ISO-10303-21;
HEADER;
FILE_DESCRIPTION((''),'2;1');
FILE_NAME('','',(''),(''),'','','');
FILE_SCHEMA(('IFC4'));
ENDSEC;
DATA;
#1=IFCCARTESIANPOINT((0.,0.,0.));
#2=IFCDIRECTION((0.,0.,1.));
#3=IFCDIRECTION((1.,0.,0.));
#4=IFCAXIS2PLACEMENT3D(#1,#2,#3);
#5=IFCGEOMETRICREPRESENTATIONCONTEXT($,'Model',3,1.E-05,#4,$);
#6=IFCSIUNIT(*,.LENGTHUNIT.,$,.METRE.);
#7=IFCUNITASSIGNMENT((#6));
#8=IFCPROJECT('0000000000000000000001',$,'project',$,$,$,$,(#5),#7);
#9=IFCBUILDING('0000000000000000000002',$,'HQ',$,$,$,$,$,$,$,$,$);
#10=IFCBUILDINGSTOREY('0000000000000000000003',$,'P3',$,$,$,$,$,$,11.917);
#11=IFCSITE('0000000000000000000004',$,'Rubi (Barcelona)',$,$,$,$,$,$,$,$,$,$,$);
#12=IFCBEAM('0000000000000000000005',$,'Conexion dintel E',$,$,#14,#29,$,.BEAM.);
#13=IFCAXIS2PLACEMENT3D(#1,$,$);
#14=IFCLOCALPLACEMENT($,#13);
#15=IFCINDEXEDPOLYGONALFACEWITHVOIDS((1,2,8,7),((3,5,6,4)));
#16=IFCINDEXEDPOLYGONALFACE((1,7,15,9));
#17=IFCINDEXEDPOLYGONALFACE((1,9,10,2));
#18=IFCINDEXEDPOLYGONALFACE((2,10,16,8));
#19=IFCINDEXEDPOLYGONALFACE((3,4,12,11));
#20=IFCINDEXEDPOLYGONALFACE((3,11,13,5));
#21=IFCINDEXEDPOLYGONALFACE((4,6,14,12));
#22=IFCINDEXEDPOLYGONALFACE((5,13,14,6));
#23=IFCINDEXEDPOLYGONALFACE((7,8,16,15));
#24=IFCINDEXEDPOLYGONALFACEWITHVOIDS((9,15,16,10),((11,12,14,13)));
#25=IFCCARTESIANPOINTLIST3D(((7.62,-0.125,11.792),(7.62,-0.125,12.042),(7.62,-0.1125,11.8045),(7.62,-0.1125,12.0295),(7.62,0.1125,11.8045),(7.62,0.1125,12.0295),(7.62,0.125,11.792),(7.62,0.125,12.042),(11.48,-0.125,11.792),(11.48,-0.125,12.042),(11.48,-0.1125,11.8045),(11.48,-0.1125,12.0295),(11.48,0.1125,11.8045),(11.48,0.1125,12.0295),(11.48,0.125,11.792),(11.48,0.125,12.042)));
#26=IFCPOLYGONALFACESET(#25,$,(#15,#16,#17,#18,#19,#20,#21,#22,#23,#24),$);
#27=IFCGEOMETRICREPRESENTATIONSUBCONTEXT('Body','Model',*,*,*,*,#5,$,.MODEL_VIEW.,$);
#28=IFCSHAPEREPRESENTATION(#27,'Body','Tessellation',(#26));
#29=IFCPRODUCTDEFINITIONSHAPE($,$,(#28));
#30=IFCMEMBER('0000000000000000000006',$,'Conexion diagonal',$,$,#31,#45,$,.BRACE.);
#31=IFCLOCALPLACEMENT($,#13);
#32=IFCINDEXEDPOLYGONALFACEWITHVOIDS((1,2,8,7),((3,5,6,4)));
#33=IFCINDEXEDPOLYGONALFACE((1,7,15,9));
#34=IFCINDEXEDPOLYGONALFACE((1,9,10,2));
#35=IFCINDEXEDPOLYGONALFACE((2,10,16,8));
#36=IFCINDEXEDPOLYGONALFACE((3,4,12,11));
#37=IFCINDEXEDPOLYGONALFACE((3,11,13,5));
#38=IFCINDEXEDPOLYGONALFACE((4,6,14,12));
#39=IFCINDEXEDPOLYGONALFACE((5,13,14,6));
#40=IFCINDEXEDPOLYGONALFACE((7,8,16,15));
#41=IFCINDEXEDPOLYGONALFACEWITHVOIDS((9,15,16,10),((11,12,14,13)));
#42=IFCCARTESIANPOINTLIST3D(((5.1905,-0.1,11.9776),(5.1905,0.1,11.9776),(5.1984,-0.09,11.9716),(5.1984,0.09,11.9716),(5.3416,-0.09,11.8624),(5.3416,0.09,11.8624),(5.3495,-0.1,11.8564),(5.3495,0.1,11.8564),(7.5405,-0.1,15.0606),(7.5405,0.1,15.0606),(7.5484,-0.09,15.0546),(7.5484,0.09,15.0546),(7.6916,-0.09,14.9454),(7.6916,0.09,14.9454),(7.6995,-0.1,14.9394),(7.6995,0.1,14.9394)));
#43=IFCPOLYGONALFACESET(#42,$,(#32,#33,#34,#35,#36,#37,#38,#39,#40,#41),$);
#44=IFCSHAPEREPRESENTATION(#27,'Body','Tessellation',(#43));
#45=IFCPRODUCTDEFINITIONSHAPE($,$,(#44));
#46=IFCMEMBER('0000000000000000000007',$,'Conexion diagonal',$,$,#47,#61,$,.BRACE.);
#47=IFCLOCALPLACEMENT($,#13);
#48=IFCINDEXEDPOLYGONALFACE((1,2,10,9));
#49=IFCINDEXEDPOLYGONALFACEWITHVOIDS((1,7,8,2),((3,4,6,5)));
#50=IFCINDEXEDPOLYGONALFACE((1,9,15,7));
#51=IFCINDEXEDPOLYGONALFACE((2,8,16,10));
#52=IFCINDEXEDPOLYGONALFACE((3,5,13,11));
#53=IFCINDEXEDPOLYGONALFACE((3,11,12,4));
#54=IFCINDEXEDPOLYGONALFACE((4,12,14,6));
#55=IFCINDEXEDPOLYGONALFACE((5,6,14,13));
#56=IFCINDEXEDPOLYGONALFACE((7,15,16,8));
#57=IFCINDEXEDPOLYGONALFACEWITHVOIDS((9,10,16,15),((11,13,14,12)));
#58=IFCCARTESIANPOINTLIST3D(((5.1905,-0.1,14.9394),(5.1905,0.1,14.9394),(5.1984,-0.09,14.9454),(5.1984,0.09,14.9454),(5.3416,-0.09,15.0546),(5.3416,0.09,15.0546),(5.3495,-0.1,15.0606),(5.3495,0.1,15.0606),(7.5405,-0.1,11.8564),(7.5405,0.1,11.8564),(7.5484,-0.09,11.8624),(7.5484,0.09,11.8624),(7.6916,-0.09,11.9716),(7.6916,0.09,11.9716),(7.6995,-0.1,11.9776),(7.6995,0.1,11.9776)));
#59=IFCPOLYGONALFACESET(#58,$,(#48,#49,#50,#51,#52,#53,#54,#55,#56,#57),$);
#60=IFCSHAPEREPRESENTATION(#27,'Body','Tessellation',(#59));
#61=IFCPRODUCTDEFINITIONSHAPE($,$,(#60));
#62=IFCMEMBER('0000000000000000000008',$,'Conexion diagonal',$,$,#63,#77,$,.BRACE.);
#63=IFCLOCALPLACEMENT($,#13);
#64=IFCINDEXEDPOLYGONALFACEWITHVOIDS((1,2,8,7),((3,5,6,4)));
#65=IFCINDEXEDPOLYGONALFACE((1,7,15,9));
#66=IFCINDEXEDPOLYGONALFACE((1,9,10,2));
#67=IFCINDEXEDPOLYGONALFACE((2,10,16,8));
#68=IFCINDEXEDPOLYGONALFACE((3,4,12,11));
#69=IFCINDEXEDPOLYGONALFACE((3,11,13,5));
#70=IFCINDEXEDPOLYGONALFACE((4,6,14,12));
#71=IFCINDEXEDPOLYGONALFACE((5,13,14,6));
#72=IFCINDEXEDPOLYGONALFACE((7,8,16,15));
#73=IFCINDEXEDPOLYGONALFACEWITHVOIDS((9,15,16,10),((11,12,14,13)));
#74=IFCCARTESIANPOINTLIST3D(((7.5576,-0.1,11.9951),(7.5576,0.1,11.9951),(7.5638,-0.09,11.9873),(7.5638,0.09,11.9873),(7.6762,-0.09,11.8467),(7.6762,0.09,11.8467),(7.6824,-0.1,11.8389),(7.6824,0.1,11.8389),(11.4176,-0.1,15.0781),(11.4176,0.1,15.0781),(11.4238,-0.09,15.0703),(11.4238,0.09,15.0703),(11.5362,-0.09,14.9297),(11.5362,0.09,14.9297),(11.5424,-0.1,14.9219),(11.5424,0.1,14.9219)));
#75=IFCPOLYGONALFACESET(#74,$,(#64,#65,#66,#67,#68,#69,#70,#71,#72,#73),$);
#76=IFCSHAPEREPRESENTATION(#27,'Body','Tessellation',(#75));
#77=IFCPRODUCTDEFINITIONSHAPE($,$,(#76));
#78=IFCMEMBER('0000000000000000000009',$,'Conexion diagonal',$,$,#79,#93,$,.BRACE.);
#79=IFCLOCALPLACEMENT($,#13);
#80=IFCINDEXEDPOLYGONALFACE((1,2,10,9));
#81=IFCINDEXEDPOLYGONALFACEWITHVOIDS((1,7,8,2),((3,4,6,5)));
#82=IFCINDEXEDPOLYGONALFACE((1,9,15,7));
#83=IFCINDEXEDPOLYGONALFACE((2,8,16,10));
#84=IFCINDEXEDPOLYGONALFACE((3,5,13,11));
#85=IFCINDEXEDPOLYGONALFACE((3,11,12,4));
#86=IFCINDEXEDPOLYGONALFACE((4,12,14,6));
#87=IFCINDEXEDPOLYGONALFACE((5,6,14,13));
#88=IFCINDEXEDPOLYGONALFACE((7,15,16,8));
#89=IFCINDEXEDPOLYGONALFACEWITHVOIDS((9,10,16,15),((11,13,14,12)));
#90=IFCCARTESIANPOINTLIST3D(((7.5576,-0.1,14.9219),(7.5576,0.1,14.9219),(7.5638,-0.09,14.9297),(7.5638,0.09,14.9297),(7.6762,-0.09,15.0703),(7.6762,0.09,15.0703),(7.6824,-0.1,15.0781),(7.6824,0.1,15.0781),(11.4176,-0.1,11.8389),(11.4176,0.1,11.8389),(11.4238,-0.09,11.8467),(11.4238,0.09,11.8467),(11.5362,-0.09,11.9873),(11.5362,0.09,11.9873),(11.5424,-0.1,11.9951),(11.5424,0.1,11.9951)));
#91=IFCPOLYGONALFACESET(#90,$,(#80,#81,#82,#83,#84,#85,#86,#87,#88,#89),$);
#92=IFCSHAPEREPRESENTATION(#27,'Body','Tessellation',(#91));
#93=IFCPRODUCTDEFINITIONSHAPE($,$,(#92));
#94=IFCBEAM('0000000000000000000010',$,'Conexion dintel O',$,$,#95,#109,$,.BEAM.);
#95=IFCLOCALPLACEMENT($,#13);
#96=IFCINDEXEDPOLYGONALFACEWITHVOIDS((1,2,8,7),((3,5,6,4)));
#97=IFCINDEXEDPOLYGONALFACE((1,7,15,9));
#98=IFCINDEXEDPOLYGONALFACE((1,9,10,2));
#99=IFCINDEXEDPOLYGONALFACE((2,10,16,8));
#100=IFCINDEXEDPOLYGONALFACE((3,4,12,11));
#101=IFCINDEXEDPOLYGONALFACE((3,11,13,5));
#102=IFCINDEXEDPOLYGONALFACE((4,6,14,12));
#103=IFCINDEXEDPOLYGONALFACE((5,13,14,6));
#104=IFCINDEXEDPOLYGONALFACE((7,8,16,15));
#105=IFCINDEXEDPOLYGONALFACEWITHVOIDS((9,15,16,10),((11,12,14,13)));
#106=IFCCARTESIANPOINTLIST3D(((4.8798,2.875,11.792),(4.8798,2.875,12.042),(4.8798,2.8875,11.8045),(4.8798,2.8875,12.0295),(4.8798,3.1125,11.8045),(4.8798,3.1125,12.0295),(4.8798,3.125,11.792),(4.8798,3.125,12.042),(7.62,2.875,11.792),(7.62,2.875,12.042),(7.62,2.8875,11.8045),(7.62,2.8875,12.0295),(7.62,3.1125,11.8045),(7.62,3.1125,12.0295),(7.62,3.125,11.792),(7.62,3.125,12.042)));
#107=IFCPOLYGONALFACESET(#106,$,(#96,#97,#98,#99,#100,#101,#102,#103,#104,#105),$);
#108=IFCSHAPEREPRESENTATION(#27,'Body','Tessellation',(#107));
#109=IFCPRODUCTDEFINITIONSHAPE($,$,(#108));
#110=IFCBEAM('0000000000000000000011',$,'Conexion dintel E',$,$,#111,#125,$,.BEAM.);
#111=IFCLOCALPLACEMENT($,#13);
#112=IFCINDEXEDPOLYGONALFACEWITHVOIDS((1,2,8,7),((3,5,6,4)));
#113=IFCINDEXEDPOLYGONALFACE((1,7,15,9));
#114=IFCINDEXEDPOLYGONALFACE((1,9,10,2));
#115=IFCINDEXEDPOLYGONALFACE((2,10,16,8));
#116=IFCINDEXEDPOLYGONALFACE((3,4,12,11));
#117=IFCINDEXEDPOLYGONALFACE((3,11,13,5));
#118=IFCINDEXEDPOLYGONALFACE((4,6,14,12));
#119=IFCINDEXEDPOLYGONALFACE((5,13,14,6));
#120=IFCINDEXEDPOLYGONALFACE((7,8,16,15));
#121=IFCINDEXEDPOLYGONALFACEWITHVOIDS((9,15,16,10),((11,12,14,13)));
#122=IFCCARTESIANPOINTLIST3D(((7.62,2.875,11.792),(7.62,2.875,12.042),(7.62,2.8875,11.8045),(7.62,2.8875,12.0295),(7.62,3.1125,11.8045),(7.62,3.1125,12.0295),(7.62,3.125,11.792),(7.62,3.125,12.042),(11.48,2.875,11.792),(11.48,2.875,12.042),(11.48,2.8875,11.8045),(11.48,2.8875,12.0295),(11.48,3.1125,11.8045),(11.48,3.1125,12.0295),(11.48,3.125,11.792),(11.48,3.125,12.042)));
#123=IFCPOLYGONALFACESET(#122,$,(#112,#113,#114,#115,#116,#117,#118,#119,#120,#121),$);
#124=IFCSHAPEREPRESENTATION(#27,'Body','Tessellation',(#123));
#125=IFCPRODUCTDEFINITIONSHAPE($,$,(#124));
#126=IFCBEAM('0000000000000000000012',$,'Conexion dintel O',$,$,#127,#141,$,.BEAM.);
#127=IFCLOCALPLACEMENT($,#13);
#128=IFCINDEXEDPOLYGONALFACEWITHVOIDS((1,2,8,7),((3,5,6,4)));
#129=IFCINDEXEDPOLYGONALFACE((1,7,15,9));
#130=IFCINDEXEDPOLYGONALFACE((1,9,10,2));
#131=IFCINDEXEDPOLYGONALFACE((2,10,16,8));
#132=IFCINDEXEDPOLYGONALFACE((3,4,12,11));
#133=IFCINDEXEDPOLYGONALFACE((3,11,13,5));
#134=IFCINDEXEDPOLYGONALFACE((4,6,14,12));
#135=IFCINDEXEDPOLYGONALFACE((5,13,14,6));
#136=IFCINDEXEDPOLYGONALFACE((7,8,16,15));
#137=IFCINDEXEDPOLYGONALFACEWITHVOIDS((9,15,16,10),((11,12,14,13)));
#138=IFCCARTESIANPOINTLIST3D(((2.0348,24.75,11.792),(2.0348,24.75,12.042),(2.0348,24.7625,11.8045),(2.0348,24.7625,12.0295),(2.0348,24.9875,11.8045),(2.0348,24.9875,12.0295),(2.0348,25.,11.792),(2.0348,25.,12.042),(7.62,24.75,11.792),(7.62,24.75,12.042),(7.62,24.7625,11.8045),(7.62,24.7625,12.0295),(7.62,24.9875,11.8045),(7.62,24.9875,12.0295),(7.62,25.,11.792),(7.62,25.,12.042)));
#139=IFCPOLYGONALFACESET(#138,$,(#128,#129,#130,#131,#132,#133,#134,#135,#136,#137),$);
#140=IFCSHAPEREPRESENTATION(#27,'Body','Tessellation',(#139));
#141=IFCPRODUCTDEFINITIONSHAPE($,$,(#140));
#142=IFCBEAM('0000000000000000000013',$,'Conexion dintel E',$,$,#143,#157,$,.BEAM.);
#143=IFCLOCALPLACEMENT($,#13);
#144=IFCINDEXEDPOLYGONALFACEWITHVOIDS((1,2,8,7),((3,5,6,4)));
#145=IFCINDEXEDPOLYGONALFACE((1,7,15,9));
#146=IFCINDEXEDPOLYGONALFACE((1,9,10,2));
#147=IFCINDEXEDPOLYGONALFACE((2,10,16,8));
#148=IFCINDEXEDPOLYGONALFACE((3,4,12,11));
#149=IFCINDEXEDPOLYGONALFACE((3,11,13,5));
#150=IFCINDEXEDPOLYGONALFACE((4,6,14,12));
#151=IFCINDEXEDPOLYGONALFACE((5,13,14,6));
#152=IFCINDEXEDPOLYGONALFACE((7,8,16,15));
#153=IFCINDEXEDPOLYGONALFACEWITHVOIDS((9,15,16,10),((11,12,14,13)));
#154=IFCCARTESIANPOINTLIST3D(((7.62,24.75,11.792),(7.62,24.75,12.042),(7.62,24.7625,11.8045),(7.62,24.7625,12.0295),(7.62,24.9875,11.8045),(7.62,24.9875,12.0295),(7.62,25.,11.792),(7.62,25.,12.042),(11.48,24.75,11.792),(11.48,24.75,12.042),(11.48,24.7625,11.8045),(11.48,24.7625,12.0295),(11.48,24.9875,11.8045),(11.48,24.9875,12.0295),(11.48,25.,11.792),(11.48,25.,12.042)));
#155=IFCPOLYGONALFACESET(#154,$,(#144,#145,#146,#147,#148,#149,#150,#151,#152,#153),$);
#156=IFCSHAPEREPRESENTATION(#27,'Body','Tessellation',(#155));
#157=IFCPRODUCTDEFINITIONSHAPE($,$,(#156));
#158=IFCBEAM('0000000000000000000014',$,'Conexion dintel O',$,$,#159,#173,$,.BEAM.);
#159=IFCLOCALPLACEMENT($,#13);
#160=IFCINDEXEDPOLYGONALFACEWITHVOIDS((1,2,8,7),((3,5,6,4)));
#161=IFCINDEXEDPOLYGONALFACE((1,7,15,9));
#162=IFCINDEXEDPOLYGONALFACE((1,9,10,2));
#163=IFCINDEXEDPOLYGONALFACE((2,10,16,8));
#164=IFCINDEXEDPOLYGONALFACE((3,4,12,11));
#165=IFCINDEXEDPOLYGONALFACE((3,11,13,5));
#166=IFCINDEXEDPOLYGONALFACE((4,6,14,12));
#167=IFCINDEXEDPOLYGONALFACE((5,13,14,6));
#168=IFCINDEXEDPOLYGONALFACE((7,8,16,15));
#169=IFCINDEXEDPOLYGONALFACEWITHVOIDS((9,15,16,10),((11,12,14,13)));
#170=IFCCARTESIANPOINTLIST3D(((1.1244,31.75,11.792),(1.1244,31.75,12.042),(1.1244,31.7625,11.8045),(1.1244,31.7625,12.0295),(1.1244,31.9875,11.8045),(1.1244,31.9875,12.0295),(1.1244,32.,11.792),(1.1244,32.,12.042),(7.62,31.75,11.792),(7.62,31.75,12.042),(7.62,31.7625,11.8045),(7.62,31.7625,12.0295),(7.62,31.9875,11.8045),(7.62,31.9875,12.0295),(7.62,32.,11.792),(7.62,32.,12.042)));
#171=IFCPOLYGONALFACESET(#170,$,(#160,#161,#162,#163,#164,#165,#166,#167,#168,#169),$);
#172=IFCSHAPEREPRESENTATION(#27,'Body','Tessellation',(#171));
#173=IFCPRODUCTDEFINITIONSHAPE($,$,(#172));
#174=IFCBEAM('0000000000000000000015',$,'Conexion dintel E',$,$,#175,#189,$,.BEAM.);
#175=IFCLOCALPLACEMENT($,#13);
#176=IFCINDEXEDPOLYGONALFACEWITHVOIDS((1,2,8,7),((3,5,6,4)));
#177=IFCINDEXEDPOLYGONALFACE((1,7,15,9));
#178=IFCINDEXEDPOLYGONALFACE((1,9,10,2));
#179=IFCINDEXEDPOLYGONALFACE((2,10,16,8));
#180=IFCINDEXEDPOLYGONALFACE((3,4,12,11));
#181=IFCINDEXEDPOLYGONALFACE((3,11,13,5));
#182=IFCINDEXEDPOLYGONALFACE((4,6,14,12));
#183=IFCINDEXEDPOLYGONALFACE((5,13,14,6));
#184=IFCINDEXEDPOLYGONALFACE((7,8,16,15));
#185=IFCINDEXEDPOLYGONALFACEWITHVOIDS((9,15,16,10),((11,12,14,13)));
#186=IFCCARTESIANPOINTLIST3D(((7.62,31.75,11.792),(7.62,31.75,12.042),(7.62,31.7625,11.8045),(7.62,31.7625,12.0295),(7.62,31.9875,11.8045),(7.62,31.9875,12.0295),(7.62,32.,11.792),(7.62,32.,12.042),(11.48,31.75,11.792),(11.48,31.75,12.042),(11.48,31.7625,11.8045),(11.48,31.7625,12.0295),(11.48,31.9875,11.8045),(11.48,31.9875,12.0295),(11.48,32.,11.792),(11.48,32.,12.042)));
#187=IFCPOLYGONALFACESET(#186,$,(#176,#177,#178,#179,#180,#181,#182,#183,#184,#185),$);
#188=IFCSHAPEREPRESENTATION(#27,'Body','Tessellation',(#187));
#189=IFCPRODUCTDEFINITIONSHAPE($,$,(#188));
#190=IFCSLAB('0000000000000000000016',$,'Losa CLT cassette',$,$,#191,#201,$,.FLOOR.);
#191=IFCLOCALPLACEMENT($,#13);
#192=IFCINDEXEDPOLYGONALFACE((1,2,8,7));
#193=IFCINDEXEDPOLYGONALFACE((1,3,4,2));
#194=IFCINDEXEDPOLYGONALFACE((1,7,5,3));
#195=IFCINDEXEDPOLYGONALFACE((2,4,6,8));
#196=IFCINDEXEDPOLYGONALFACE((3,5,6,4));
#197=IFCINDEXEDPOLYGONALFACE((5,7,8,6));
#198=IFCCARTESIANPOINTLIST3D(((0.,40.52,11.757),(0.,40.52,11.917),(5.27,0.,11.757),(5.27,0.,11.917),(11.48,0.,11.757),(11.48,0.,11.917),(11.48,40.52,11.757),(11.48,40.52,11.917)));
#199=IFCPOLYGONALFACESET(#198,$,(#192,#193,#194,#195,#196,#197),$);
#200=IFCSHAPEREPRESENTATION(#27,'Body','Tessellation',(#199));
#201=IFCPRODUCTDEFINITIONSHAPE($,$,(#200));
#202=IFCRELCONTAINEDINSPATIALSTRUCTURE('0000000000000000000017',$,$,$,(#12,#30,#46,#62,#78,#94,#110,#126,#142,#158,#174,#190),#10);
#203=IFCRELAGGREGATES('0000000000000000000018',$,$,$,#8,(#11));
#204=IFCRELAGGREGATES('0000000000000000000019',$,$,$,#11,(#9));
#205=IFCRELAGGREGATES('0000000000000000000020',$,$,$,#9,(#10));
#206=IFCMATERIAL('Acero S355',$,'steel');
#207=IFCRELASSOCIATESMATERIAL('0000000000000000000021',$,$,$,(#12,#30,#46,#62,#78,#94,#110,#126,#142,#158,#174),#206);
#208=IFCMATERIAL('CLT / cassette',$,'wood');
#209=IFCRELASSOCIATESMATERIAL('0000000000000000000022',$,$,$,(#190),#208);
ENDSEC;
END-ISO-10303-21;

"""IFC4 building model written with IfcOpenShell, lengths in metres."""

from ifc_helpers import new_model, si_unit, frame, origin_with_axes, place, context, subcontext, project, spatial, polyline, hollow_rectangle, outline, extrude, material, element, save


model = new_model("IFC4")

# Units and contexts
model_context = context("Model", 3, precision=1e-05, world=origin_with_axes())
body_context = subcontext(model_context, "Body", "Model", "MODEL_VIEW")
ifc_project = project(units=[si_unit("LENGTHUNIT", "METRE")], contexts=[model_context])

# Site, building, storey
site = spatial("IfcSite", under=ifc_project, Name="Rubi (Barcelona)")
building = spatial("IfcBuilding", under=site, Name="HQ")
storey = spatial("IfcBuildingStorey", under=building, Name="P3", Elevation=11.917)

# Beam
ifc_material_1 = material(Name="Acero S355", Category="steel")
beam_1_placement = place(None, origin_with_axes())
element("IfcBeam", 1, at=beam_1_placement, inside=storey, material=ifc_material_1, Name="Conexion dintel E", PredefinedType="BEAM", context=body_context, shape_type="SweptSolid", body=[
    extrude(hollow_rectangle(XDim=0.25, YDim=0.25, WallThickness=0.0125), frame((7.62, 0.0, 11.917), z_axis=(1.0, 0.0, 0.0), x_axis=(0.0, 1.0, 0.0)), (0.0, 0.0, 1.0), 3.86),
])

# Members
member_1_placement = place(None, origin_with_axes())
element("IfcMember", 2, at=member_1_placement, inside=storey, material=ifc_material_1, Name="Conexion diagonal", PredefinedType="BRACE", context=body_context, shape_type="SweptSolid", body=[
    extrude(hollow_rectangle(XDim=0.2, YDim=0.2, WallThickness=0.01), frame((5.27, 0.0, 11.917), z_axis=(0.606214, 0.0, 0.795301), x_axis=(0.0, 1.0, 0.0)), (0.0, 0.0, 1.0), 3.8765),
])
member_2_placement = place(None, origin_with_axes())
element("IfcMember", 3, at=member_2_placement, inside=storey, material=ifc_material_1, Name="Conexion diagonal", PredefinedType="BRACE", context=body_context, shape_type="SweptSolid", body=[
    extrude(hollow_rectangle(XDim=0.2, YDim=0.2, WallThickness=0.01), frame((7.62, 0.0, 11.917), z_axis=(-0.606214, 0.0, 0.795301), x_axis=(0.0, -1.0, 0.0)), (0.0, 0.0, 1.0), 3.8765),
])
member_3_placement = place(None, origin_with_axes())
element("IfcMember", 4, at=member_3_placement, inside=storey, material=ifc_material_1, Name="Conexion diagonal", PredefinedType="BRACE", context=body_context, shape_type="SweptSolid", body=[
    extrude(hollow_rectangle(XDim=0.2, YDim=0.2, WallThickness=0.01), frame((7.62, 0.0, 11.917), z_axis=(0.781362, 0.0, 0.624078), x_axis=(0.0, 1.0, 0.0)), (0.0, 0.0, 1.0), 4.9401),
])
member_4_placement = place(None, origin_with_axes())
element("IfcMember", 5, at=member_4_placement, inside=storey, material=ifc_material_1, Name="Conexion diagonal", PredefinedType="BRACE", context=body_context, shape_type="SweptSolid", body=[
    extrude(hollow_rectangle(XDim=0.2, YDim=0.2, WallThickness=0.01), frame((11.48, 0.0, 11.917), z_axis=(-0.781362, 0.0, 0.624078), x_axis=(0.0, -1.0, 0.0)), (0.0, 0.0, 1.0), 4.9401),
])

# Beams
beam_2_placement = place(None, origin_with_axes())
element("IfcBeam", 6, at=beam_2_placement, inside=storey, material=ifc_material_1, Name="Conexion dintel O", PredefinedType="BEAM", context=body_context, shape_type="SweptSolid", body=[
    extrude(hollow_rectangle(XDim=0.25, YDim=0.25, WallThickness=0.0125), frame((4.8798, 3.0, 11.917), z_axis=(1.0, 0.0, 0.0), x_axis=(0.0, 1.0, 0.0)), (0.0, 0.0, 1.0), 2.7402),
])
beam_3_placement = place(None, origin_with_axes())
element("IfcBeam", 7, at=beam_3_placement, inside=storey, material=ifc_material_1, Name="Conexion dintel E", PredefinedType="BEAM", context=body_context, shape_type="SweptSolid", body=[
    extrude(hollow_rectangle(XDim=0.25, YDim=0.25, WallThickness=0.0125), frame((7.62, 3.0, 11.917), z_axis=(1.0, 0.0, 0.0), x_axis=(0.0, 1.0, 0.0)), (0.0, 0.0, 1.0), 3.86),
])
beam_4_placement = place(None, origin_with_axes())
element("IfcBeam", 8, at=beam_4_placement, inside=storey, material=ifc_material_1, Name="Conexion dintel O", PredefinedType="BEAM", context=body_context, shape_type="SweptSolid", body=[
    extrude(hollow_rectangle(XDim=0.25, YDim=0.25, WallThickness=0.0125), frame((2.0348, 24.875, 11.917), z_axis=(1.0, 0.0, 0.0), x_axis=(0.0, 1.0, 0.0)), (0.0, 0.0, 1.0), 5.5852),
])
beam_5_placement = place(None, origin_with_axes())
element("IfcBeam", 9, at=beam_5_placement, inside=storey, material=ifc_material_1, Name="Conexion dintel E", PredefinedType="BEAM", context=body_context, shape_type="SweptSolid", body=[
    extrude(hollow_rectangle(XDim=0.25, YDim=0.25, WallThickness=0.0125), frame((7.62, 24.875, 11.917), z_axis=(1.0, 0.0, 0.0), x_axis=(0.0, 1.0, 0.0)), (0.0, 0.0, 1.0), 3.86),
])
beam_6_placement = place(None, origin_with_axes())
element("IfcBeam", 10, at=beam_6_placement, inside=storey, material=ifc_material_1, Name="Conexion dintel O", PredefinedType="BEAM", context=body_context, shape_type="SweptSolid", body=[
    extrude(hollow_rectangle(XDim=0.25, YDim=0.25, WallThickness=0.0125), frame((1.1244, 31.875, 11.917), z_axis=(1.0, 0.0, 0.0), x_axis=(0.0, 1.0, 0.0)), (0.0, 0.0, 1.0), 6.4956),
])
beam_7_placement = place(None, origin_with_axes())
element("IfcBeam", 11, at=beam_7_placement, inside=storey, material=ifc_material_1, Name="Conexion dintel E", PredefinedType="BEAM", context=body_context, shape_type="SweptSolid", body=[
    extrude(hollow_rectangle(XDim=0.25, YDim=0.25, WallThickness=0.0125), frame((7.62, 31.875, 11.917), z_axis=(1.0, 0.0, 0.0), x_axis=(0.0, 1.0, 0.0)), (0.0, 0.0, 1.0), 3.86),
])

# Slab
ifc_material_2 = material(Name="CLT / cassette", Category="wood")
slab_placement = place(None, origin_with_axes())
element("IfcSlab", 12, at=slab_placement, inside=storey, material=ifc_material_2, Name="Losa CLT cassette", PredefinedType="FLOOR", context=body_context, shape_type="SweptSolid", body=[
    extrude(outline(polyline([(5.27, 0.0, 0.0), (11.48, 0.0, 0.0), (11.48, 40.52, 0.0), (0.0, 40.52, 0.0), (5.27, 0.0, 0.0)])), frame((0.0, 0.0, 11.757)), (0.0, 0.0, 1.0), 0.16),
])

save(model, "model.ifc")
